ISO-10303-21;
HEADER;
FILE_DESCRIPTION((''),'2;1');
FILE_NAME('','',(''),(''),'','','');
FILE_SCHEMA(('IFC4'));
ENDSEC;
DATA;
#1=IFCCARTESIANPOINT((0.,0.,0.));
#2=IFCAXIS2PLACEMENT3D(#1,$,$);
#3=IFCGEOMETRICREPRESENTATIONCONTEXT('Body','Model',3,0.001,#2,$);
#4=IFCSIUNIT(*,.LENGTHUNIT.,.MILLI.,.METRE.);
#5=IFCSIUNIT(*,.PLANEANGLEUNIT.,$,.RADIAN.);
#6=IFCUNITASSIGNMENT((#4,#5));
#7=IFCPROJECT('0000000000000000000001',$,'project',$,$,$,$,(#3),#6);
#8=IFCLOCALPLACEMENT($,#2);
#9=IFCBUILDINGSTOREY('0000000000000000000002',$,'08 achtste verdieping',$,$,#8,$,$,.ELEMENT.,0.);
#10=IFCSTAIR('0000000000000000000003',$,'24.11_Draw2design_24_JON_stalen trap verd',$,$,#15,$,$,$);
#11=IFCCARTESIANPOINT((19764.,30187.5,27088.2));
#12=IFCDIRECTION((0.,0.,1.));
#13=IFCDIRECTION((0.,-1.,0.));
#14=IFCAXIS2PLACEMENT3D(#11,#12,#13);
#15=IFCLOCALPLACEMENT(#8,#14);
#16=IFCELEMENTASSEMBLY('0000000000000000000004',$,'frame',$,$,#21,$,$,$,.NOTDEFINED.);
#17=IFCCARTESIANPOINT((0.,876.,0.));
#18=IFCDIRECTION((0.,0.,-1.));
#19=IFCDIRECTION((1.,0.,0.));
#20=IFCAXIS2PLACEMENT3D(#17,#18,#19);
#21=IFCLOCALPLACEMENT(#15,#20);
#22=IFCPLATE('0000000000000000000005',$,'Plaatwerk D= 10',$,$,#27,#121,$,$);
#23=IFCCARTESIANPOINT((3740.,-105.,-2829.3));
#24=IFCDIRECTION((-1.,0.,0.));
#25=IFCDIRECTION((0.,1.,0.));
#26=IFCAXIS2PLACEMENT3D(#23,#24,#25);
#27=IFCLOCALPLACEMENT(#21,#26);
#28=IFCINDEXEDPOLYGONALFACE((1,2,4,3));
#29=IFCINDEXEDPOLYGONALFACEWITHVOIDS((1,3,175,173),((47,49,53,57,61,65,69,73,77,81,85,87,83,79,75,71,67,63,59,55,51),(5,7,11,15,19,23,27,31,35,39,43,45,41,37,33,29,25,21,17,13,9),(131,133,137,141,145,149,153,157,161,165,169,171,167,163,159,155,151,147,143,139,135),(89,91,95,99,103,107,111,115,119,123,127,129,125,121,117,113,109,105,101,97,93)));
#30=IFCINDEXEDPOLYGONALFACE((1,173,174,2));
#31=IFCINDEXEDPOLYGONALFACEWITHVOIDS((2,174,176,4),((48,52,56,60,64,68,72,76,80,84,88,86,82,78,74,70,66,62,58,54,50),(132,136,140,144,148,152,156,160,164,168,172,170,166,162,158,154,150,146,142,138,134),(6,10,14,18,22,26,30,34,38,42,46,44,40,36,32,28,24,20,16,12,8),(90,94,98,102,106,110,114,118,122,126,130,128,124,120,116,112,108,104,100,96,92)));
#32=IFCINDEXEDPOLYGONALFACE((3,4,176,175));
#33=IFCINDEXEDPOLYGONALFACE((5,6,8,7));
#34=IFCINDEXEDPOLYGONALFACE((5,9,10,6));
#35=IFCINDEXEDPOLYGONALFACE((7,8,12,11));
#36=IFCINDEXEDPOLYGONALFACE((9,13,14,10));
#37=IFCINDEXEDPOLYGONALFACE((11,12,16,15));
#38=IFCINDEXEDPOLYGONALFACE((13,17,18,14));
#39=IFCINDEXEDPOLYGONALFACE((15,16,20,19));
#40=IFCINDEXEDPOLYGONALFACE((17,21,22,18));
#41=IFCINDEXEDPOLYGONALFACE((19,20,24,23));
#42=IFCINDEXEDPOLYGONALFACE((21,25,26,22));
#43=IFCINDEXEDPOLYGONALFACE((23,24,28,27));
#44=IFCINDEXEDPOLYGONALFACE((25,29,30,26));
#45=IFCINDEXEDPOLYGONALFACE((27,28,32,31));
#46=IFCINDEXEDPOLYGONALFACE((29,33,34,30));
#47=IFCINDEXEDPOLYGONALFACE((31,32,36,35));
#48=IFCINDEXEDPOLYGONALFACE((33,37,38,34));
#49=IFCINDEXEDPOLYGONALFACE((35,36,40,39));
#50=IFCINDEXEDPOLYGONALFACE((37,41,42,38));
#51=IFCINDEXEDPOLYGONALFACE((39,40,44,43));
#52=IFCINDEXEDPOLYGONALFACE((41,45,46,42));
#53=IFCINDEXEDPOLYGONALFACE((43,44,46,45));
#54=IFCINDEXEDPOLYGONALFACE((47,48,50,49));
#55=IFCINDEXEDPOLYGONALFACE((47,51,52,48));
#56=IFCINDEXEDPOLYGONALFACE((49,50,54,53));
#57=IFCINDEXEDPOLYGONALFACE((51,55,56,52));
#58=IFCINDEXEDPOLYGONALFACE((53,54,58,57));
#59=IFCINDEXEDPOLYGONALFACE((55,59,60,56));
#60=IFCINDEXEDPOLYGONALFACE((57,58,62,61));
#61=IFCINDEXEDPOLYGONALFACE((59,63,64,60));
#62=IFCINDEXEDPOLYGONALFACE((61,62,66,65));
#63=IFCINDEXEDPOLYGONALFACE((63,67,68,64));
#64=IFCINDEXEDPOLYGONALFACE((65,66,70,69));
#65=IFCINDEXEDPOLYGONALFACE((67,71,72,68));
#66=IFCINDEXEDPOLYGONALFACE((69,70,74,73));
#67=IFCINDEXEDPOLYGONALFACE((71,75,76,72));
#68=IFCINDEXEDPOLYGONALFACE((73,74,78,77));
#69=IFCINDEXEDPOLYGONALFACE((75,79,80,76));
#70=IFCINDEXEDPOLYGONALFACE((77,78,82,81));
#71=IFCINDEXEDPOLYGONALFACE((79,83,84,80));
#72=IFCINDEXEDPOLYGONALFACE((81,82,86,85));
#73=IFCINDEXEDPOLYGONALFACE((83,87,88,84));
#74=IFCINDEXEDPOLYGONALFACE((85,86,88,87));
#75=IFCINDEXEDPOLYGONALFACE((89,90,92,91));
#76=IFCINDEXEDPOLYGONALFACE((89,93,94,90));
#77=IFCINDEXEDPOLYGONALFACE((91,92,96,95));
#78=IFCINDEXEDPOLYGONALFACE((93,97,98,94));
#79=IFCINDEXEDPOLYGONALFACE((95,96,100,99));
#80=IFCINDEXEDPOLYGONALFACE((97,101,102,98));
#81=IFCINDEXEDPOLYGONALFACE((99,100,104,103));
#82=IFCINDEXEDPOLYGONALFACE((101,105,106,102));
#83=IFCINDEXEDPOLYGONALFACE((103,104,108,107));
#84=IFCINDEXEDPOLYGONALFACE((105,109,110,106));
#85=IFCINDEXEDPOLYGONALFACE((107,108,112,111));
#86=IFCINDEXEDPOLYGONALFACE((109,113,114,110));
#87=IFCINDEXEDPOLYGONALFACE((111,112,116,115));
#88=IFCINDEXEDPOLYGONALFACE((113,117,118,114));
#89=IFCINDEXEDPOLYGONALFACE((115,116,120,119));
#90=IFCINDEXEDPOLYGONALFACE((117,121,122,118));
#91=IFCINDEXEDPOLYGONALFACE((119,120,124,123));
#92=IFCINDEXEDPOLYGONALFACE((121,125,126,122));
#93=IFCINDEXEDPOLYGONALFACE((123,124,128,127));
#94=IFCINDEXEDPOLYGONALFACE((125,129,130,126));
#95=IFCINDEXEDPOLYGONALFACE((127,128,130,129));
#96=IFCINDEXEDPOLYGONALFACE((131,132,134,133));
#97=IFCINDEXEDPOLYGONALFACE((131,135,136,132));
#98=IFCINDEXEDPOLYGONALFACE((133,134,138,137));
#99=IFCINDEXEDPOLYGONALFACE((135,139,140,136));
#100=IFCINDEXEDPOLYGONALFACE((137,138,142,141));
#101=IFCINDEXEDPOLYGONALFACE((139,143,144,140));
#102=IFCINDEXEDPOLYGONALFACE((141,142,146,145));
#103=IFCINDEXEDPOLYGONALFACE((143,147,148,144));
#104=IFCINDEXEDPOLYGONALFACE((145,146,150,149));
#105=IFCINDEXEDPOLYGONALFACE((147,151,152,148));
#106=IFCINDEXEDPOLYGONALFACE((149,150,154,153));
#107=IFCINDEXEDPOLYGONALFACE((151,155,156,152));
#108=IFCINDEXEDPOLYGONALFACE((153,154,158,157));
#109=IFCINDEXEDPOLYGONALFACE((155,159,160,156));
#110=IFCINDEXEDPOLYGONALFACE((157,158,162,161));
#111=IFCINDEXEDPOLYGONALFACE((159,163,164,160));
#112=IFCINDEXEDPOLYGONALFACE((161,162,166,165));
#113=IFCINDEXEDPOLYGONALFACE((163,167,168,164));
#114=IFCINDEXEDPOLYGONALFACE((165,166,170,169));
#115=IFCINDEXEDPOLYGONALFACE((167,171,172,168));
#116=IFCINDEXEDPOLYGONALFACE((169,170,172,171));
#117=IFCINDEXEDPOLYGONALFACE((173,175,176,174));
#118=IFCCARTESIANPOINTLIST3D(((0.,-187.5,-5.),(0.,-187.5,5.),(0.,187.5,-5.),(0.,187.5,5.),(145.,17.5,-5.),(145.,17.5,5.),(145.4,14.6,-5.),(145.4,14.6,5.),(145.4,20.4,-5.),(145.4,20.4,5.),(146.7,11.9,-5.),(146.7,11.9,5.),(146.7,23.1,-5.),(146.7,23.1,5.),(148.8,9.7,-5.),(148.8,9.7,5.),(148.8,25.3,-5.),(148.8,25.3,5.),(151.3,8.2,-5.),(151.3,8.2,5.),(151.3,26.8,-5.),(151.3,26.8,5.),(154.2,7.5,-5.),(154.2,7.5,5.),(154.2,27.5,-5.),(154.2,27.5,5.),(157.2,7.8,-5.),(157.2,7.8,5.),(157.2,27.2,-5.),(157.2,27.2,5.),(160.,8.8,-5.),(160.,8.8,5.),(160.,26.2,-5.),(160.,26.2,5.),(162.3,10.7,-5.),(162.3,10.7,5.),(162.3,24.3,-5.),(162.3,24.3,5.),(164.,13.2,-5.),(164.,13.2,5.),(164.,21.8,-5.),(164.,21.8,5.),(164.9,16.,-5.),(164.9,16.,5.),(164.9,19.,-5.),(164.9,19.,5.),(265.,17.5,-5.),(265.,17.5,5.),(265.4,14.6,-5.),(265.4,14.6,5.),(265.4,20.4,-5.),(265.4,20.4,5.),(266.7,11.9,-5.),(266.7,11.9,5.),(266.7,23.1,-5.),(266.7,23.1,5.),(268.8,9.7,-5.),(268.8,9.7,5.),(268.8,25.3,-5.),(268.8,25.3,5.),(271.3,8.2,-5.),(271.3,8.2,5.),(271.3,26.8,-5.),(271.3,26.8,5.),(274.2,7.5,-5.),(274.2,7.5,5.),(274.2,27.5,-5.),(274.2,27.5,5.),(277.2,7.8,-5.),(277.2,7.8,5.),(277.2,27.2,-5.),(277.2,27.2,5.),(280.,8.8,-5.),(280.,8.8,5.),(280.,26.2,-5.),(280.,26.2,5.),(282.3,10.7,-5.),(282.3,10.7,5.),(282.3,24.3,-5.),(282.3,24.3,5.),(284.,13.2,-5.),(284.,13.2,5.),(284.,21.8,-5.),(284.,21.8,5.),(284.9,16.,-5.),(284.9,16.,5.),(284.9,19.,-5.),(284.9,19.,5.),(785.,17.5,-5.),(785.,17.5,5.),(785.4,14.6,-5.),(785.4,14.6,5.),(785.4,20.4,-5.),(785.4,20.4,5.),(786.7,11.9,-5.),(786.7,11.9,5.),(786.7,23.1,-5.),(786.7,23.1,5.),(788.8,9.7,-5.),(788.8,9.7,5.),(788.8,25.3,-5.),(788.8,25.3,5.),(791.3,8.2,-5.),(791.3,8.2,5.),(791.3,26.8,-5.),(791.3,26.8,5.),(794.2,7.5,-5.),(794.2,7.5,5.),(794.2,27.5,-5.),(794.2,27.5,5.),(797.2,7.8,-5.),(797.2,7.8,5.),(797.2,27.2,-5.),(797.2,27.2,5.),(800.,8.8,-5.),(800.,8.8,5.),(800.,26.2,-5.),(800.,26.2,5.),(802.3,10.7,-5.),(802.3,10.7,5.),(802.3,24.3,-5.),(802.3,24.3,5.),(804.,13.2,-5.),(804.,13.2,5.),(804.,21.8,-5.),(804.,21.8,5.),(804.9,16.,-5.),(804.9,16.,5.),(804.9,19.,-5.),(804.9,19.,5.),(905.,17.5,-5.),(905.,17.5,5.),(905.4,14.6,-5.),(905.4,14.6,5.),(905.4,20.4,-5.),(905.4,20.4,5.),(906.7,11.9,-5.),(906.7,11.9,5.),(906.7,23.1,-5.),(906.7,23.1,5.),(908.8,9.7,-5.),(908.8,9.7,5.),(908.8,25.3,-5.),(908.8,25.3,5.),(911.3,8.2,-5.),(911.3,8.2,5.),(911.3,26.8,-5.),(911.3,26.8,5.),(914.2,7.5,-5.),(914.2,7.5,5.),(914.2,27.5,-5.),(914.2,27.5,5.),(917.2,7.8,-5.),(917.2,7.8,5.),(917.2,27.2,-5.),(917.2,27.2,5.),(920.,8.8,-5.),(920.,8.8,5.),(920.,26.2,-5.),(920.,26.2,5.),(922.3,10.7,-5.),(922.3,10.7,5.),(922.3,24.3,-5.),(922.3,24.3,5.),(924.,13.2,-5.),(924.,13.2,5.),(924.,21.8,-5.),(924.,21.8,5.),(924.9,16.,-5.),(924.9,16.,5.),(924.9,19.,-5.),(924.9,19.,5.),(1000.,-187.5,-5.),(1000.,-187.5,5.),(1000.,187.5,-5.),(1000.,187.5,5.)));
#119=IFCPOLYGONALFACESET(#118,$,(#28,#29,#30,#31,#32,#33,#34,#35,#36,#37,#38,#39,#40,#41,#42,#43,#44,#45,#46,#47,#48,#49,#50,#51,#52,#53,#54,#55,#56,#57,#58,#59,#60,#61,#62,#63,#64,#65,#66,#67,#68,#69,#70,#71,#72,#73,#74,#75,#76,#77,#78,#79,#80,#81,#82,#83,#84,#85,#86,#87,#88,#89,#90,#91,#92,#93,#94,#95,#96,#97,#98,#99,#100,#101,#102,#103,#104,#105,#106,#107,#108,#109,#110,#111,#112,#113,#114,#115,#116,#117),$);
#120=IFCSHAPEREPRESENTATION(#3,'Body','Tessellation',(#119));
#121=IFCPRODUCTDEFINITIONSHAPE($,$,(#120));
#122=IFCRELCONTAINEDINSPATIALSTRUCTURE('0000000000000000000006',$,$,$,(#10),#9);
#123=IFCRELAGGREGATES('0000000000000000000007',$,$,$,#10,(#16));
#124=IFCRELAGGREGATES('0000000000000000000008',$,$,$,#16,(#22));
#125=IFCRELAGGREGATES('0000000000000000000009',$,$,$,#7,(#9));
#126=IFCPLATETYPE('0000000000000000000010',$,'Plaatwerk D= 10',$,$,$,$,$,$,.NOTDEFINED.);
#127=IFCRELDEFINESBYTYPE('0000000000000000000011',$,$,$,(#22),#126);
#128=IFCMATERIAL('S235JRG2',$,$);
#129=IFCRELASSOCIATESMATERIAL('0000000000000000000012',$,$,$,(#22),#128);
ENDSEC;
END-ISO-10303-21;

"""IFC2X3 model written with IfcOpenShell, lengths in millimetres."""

from ifc_helpers import new_model, si_unit, frame, origin, origin_2d, place, context, project, spatial, rectangle, circle, extrude, source, transform, mapped, material, type_object, element, aggregate, save


model = new_model("IFC2X3")

# Units and contexts
model_context = context("Model", 3, precision=0.001, world=origin(), identifier="Body")
ifc_project = project(units=[si_unit("LENGTHUNIT", "METRE", prefix="MILLI"), si_unit("PLANEANGLEUNIT", "RADIAN")], contexts=[model_context])

# Storey
storey_placement = place(None, origin())
storey = spatial("IfcBuildingStorey", under=ifc_project, at=storey_placement, Name="08 achtste verdieping", CompositionType="ELEMENT", Elevation=0.0)

# Stair
stair_placement = place(storey_placement, frame((19764.0, 30187.5, 27088.2), z_axis=(0.0, 0.0, 1.0), x_axis=(0.0, -1.0, 0.0)))
stair = element("IfcStair", 1, at=stair_placement, inside=storey, Name="24.11_Draw2design_24_JON_stalen trap verd")
ifc_material_1 = material(Name="S235JRG2")

# Element assembly
assembly_placement = place(stair_placement, frame((0.0, 876.0, 0.0), z_axis=(0.0, 0.0, -1.0), x_axis=(1.0, 0.0, 0.0)))
assembly = element("IfcElementAssembly", 2, at=assembly_placement, Name="frame", PredefinedType="NOTDEFINED")
aggregate(stair, [assembly])

# Plate, openings
plate_type = type_object("IfcPlateType", Name="Plaatwerk D= 10")
shared_shape_1 = source(origin(), model_context, "Body", "SweptSolid", [
    extrude(rectangle(XDim=1000.0, YDim=375.0, at=origin_2d()), frame((500.0, 0.0, -5.0)), (0.0, 0.0, 1.0), 10.0),
])
plate_placement = place(assembly_placement, frame((3740.0, -105.0, -2829.3), z_axis=(-1.0, 0.0, 0.0), x_axis=(0.0, 1.0, 0.0)))
plate = element("IfcPlate", 3, at=plate_placement, type_object=plate_type, material=ifc_material_1, Name="Plaatwerk D= 10", context=model_context, shape_type="MappedRepresentation", body=[
    mapped(shared_shape_1, transform((0.0, 0.0, 0.0), scale=1.0)),
])
opening_1_placement = place(plate_placement, frame((795.0, 17.5, -5.0), z_axis=(0.0, 0.0, 1.0), x_axis=(-1.0, 0.0, 0.0)))
element("IfcOpeningElement", 4, at=opening_1_placement, cuts=plate, ObjectType="Opening", context=model_context, shape_type="SweptSolid", body=[
    extrude(circle(Radius=10.0, at=origin_2d()), origin(), (0.0, 0.0, 1.0), 10.0),
])
opening_2_placement = place(plate_placement, frame((915.0, 17.5, -5.0), z_axis=(0.0, 0.0, 1.0), x_axis=(-1.0, 0.0, 0.0)))
element("IfcOpeningElement", 5, at=opening_2_placement, cuts=plate, ObjectType="Opening", context=model_context, shape_type="SweptSolid", body=[
    extrude(circle(Radius=10.0, at=origin_2d()), origin(), (0.0, 0.0, 1.0), 10.0),
])
opening_3_placement = place(plate_placement, frame((155.0, 17.5, -5.0), z_axis=(0.0, 0.0, 1.0), x_axis=(-1.0, 0.0, 0.0)))
element("IfcOpeningElement", 6, at=opening_3_placement, cuts=plate, ObjectType="Opening", context=model_context, shape_type="SweptSolid", body=[
    extrude(circle(Radius=10.0, at=origin_2d()), origin(), (0.0, 0.0, 1.0), 10.0),
])
opening_4_placement = place(plate_placement, frame((275.0, 17.5, -5.0), z_axis=(0.0, 0.0, 1.0), x_axis=(-1.0, 0.0, 0.0)))
element("IfcOpeningElement", 7, at=opening_4_placement, cuts=plate, ObjectType="Opening", context=model_context, shape_type="SweptSolid", body=[
    extrude(circle(Radius=10.0, at=origin_2d()), origin(), (0.0, 0.0, 1.0), 10.0),
])
aggregate(assembly, [plate])

save(model, "model.ifc")
